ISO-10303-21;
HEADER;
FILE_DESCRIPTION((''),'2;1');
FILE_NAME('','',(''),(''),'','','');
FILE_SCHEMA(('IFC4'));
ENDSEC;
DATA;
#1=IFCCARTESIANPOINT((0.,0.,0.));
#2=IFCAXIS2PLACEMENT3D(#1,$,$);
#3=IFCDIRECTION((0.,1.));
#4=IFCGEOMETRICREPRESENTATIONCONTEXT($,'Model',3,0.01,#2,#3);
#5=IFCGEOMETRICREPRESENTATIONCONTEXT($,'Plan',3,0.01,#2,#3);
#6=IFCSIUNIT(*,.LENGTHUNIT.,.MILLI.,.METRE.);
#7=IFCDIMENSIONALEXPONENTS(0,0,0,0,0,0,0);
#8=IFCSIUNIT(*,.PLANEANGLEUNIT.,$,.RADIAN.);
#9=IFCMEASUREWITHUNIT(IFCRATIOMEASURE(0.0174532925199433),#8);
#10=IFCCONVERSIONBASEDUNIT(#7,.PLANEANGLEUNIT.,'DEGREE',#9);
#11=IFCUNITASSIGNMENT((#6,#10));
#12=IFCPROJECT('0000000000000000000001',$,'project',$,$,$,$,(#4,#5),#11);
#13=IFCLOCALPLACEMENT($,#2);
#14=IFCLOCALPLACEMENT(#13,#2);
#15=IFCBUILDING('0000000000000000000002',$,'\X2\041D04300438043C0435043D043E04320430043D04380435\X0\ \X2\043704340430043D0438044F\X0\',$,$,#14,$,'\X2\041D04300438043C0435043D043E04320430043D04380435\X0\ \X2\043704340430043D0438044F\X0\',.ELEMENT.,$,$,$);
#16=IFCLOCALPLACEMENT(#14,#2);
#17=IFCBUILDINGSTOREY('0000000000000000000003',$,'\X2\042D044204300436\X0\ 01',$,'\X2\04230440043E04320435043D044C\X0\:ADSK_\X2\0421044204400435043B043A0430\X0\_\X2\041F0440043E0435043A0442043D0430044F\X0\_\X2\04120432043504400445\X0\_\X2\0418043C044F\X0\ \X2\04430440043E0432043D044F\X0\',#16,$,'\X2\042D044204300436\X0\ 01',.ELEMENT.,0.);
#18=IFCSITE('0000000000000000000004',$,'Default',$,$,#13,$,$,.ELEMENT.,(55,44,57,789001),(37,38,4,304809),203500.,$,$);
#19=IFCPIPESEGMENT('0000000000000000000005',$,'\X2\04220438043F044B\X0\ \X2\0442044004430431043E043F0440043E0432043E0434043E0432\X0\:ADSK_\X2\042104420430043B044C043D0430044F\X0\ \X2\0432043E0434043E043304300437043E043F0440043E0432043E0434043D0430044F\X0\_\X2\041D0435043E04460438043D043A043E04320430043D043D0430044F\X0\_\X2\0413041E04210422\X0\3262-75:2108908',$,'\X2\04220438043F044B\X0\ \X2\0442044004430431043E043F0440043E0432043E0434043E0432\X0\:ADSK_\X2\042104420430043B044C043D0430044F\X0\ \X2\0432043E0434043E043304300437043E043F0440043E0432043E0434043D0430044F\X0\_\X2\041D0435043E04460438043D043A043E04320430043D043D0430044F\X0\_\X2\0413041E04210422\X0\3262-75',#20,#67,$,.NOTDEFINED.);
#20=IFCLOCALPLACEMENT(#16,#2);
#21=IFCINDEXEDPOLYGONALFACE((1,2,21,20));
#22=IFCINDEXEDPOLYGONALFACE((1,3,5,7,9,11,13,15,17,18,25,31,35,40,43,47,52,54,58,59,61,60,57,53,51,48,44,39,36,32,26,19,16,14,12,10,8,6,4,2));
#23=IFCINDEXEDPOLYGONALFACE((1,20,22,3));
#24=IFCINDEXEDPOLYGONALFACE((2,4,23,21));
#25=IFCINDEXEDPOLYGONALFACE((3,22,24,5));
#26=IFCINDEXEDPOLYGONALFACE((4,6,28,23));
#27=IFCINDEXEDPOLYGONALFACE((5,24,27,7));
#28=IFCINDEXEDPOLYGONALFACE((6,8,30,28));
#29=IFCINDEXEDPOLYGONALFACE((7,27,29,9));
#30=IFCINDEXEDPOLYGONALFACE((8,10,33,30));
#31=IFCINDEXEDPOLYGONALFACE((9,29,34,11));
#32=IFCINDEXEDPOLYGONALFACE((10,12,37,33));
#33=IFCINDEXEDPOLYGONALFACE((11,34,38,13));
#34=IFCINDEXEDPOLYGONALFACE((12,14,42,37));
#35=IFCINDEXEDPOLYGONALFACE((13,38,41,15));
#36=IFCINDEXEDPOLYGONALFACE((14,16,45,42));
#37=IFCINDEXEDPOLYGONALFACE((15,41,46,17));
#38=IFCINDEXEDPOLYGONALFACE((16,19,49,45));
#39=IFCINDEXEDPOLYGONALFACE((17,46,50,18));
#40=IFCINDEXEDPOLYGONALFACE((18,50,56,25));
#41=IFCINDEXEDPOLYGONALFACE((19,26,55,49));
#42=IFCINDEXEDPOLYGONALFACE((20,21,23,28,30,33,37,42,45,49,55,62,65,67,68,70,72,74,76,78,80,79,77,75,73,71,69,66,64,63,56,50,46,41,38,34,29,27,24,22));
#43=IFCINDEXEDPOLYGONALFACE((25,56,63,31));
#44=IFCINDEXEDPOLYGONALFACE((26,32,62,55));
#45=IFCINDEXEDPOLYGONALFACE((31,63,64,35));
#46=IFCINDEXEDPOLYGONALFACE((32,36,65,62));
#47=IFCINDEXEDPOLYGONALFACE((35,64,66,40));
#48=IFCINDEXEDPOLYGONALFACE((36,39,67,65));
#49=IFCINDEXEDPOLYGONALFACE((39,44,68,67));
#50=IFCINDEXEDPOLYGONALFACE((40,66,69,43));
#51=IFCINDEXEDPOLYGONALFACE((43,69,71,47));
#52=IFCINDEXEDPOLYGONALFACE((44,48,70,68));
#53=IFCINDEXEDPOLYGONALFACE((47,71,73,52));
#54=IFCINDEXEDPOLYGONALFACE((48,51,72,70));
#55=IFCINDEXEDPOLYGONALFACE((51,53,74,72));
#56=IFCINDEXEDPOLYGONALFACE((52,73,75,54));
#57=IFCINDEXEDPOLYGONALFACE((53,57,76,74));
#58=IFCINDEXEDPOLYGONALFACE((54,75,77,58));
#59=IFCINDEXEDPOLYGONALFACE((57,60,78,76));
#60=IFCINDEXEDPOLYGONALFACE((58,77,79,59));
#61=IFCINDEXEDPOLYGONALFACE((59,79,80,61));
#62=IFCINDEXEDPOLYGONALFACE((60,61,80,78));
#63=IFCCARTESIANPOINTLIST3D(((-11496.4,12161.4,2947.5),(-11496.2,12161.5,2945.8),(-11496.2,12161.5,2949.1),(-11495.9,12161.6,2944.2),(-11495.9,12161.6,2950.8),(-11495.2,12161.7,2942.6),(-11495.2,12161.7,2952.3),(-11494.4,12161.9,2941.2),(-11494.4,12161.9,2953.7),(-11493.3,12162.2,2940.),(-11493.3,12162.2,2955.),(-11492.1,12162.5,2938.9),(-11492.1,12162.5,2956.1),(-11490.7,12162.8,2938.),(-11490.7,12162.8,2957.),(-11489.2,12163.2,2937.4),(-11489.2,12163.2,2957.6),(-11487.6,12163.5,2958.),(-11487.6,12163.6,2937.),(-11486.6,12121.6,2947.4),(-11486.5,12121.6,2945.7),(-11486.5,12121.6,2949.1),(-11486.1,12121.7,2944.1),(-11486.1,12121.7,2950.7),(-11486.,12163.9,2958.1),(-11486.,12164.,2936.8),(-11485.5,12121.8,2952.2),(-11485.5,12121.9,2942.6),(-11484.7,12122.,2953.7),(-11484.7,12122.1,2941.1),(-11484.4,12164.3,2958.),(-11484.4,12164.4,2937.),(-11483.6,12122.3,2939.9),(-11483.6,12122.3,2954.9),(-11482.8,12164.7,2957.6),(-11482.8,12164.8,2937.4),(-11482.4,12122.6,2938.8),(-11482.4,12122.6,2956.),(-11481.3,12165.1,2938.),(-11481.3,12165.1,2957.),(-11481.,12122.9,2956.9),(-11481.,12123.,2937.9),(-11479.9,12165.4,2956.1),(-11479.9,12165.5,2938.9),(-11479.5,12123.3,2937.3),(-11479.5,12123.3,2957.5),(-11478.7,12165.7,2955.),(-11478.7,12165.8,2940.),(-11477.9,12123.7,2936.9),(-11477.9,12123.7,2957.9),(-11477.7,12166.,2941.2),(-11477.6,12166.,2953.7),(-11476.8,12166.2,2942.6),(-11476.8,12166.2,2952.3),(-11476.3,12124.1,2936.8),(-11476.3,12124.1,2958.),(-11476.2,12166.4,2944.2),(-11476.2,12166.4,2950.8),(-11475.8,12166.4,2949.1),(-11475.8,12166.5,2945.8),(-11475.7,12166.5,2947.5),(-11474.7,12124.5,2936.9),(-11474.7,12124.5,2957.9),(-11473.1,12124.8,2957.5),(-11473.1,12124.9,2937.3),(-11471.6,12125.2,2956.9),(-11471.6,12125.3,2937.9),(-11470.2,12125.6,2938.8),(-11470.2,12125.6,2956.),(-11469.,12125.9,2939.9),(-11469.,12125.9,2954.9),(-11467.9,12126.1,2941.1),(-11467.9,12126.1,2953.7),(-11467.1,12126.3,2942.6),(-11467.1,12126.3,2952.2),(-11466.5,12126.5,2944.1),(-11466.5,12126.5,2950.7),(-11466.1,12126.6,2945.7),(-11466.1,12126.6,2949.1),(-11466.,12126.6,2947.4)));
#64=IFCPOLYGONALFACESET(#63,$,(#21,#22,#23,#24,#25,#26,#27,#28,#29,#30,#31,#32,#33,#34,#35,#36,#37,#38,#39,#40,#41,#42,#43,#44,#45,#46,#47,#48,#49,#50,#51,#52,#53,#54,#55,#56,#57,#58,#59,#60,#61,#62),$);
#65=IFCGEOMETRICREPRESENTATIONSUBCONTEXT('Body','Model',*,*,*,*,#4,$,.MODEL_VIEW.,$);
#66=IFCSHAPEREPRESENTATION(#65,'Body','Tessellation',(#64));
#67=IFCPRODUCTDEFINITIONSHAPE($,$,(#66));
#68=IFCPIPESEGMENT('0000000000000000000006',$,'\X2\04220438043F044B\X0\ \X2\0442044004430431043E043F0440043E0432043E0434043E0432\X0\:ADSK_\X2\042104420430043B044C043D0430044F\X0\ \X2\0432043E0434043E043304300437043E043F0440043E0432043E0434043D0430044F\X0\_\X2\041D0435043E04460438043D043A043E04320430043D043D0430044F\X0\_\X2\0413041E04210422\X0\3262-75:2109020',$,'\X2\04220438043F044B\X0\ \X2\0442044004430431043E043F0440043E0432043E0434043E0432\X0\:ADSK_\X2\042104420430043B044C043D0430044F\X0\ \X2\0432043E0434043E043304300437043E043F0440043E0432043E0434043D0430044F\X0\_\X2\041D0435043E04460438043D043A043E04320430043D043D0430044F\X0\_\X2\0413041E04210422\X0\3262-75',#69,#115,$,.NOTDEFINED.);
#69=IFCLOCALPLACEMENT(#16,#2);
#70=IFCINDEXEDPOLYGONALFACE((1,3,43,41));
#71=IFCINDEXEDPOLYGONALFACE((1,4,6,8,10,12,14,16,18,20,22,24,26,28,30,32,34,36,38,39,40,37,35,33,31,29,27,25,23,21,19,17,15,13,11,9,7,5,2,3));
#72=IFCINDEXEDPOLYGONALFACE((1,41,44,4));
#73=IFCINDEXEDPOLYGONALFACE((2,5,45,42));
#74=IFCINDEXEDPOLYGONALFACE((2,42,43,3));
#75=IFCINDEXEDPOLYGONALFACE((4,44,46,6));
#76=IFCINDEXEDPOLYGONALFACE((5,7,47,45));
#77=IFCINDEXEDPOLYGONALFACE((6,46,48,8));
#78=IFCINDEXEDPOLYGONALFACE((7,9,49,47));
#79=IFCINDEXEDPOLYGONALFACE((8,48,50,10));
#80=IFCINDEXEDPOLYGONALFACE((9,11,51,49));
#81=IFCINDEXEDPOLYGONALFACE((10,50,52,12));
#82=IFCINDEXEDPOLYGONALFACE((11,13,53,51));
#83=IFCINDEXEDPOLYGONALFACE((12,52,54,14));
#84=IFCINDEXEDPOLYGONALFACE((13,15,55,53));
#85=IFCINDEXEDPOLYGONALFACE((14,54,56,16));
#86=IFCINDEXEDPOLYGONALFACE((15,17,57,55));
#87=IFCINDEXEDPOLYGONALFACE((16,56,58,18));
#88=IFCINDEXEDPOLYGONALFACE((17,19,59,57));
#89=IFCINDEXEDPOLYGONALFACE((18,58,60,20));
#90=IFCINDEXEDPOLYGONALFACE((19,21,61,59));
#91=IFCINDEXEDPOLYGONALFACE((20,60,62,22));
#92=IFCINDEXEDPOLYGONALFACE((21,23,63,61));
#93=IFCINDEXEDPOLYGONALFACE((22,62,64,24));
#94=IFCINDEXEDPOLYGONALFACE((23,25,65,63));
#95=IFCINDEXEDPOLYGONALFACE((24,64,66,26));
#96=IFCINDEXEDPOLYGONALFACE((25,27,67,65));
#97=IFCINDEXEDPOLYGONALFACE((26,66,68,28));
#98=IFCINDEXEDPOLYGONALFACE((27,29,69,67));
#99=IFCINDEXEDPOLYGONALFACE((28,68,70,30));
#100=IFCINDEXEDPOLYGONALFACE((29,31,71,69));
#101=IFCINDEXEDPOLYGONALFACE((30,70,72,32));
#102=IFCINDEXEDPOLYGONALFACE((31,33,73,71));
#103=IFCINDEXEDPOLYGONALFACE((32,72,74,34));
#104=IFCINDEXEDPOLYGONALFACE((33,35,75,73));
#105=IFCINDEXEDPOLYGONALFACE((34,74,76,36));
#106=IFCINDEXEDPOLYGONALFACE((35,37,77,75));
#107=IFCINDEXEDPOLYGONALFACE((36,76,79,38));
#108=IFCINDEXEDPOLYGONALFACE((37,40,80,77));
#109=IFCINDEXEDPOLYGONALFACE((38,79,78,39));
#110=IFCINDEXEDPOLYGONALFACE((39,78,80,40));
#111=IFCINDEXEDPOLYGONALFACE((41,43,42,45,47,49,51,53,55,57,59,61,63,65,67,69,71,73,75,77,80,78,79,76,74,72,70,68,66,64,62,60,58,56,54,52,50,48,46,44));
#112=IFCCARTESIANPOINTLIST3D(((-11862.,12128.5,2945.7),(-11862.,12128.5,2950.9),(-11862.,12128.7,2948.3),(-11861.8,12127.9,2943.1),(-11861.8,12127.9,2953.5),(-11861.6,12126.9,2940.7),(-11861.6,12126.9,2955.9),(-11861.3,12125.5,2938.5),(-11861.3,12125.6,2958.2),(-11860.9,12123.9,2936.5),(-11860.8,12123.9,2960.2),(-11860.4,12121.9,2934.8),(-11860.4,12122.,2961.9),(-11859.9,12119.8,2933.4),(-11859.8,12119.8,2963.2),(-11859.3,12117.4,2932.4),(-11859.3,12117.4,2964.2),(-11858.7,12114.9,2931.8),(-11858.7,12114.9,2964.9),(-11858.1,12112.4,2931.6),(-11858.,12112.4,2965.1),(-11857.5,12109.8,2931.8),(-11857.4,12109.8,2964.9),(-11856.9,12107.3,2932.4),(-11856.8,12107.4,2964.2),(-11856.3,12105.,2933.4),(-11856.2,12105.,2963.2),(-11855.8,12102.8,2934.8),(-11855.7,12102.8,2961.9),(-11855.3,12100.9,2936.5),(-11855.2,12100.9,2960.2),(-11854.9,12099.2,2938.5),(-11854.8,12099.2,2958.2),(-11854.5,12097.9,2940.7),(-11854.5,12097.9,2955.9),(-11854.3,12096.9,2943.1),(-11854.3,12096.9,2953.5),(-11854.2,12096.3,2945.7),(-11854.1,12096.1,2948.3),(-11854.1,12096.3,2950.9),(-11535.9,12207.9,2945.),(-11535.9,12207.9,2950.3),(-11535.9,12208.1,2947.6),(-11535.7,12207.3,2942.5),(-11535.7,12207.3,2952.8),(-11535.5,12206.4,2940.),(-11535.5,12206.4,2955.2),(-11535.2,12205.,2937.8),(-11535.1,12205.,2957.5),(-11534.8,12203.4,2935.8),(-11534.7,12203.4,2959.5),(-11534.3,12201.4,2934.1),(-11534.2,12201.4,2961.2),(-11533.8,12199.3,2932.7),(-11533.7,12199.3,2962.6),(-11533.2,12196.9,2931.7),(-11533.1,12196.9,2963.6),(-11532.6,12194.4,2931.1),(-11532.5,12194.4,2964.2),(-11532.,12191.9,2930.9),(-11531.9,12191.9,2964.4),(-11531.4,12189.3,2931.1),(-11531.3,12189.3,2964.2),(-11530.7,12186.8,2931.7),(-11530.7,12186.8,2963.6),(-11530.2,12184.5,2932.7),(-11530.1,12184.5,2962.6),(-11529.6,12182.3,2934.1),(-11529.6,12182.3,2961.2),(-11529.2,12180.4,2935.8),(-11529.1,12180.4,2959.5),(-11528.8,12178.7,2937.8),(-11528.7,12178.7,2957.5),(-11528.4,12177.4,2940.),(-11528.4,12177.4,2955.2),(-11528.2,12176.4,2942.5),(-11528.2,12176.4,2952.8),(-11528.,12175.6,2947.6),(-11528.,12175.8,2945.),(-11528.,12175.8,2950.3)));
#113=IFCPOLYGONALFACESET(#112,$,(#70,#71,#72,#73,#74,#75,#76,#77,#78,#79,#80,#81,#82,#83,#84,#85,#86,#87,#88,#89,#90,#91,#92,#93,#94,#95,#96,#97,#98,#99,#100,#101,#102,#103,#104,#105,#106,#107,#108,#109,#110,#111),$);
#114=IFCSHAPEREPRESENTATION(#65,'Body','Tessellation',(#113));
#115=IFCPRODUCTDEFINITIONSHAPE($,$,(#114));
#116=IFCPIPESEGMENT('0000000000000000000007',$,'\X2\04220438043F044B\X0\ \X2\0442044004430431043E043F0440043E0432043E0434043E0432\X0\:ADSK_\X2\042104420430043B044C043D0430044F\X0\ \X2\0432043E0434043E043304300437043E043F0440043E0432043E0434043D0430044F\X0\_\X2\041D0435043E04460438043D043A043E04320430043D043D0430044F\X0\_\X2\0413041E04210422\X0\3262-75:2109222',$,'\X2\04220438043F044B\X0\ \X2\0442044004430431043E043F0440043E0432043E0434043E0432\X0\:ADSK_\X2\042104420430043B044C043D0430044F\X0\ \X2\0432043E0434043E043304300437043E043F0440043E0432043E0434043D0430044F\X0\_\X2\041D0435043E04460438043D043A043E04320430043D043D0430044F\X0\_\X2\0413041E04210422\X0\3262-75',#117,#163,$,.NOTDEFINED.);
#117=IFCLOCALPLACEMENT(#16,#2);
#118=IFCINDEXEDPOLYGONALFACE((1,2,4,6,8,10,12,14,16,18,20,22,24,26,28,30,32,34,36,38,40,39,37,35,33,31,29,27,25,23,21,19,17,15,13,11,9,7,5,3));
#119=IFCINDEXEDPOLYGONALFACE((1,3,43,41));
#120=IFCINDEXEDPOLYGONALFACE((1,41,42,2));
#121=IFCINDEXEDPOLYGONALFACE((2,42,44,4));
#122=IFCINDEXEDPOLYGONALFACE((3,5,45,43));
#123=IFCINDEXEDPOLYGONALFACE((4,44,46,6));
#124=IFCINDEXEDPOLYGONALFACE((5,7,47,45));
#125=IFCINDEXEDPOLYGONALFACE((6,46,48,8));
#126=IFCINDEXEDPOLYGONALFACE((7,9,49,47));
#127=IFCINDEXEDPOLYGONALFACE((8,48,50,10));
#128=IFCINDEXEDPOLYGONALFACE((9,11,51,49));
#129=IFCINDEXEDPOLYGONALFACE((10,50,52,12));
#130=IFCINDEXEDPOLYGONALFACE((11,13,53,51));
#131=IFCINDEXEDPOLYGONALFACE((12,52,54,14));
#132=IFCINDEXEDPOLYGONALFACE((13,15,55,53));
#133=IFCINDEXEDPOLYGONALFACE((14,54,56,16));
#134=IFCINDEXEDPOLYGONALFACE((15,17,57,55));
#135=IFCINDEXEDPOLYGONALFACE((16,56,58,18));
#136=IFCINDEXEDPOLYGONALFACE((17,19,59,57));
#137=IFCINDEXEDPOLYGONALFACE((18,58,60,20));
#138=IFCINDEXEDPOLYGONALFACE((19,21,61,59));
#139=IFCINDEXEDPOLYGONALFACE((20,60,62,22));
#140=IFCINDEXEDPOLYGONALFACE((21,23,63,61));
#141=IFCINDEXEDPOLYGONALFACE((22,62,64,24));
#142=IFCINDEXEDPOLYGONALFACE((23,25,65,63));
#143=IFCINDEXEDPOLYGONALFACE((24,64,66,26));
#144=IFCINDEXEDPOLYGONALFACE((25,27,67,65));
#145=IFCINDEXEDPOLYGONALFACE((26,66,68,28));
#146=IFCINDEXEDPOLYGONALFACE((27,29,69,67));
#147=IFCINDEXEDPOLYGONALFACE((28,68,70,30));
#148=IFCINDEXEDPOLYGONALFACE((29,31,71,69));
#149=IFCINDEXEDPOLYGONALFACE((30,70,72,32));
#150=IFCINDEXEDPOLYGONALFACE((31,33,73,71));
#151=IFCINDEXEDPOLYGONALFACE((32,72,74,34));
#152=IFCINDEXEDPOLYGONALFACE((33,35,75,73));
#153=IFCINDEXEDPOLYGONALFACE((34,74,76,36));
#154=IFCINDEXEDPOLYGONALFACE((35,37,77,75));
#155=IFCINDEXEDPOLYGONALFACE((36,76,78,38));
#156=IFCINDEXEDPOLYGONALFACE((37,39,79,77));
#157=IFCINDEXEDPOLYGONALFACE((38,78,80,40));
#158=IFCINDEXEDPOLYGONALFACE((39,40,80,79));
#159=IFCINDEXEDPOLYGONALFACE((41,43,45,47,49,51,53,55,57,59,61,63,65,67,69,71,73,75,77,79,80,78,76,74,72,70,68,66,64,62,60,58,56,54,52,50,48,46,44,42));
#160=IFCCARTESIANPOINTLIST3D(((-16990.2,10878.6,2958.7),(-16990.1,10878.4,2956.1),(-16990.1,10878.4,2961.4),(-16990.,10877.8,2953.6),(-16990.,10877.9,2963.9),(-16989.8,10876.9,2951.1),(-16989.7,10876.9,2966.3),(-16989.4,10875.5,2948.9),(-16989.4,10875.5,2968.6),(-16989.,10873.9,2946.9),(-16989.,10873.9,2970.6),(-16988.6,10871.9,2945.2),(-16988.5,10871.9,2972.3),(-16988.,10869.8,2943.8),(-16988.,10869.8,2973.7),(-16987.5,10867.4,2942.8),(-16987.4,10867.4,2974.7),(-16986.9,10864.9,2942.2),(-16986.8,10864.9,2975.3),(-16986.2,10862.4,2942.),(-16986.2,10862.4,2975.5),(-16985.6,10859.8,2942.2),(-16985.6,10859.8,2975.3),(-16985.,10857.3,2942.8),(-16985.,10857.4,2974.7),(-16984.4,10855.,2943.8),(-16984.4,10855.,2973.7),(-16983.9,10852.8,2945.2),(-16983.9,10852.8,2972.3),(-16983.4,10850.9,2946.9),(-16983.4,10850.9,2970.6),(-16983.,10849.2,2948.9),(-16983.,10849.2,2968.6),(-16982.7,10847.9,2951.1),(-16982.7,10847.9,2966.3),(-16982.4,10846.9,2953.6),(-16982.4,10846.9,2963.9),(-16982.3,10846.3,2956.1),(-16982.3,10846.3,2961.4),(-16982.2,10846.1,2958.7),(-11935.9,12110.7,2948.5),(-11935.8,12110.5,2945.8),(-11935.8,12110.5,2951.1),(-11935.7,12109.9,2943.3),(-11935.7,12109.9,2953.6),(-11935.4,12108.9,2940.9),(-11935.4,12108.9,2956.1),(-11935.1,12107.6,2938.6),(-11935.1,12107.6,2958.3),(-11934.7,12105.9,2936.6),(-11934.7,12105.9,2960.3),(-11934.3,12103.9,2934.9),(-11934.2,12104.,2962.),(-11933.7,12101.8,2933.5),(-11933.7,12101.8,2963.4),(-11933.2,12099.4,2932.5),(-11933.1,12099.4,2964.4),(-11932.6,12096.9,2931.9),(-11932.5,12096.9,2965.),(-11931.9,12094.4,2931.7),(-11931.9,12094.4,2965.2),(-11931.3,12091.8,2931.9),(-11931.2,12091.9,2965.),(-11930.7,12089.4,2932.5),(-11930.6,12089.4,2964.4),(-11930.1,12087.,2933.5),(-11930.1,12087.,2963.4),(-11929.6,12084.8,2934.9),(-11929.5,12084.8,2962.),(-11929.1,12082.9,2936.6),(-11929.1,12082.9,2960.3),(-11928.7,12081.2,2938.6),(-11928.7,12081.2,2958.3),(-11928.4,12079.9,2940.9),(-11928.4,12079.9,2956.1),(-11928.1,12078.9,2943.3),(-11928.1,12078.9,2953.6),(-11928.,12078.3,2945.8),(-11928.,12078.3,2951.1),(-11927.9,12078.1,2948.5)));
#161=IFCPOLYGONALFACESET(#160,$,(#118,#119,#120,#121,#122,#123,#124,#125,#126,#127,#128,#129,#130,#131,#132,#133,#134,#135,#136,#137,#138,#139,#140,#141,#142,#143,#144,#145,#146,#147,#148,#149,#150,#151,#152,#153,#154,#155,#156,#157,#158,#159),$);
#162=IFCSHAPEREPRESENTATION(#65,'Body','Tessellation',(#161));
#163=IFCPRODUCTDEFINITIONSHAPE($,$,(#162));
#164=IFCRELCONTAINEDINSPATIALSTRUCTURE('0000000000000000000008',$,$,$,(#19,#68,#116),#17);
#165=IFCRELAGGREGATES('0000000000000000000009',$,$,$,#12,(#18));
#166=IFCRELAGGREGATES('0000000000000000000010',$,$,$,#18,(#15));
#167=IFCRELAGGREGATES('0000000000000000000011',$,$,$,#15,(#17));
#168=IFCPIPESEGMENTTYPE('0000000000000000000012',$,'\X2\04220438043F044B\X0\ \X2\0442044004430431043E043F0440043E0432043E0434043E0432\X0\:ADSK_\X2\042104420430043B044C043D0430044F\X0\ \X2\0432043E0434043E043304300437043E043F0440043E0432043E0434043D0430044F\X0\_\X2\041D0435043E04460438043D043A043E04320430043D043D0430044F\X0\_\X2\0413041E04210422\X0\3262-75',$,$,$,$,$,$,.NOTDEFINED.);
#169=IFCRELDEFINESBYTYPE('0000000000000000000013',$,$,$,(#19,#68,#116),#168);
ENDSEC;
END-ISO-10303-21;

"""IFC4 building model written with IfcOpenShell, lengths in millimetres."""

from ifc_helpers import new_model, entity, si_unit, converted_unit, direction, frame, origin, place, context, subcontext, project, spatial, indexed_curve, outline, extrude, type_object, element, save


model = new_model("IFC4")

# Units and contexts
model_context = context("Model", 3, precision=0.01, world=origin(), true_north=direction((0.0, 1.0)))
plan_context = context("Plan", 3, precision=0.01, world=origin(), true_north=direction((0.0, 1.0)))
body_context = subcontext(model_context, "Body", "Model", "MODEL_VIEW")
ifc_project = project(units=[si_unit("LENGTHUNIT", "METRE", prefix="MILLI"), converted_unit("PLANEANGLEUNIT", "DEGREE", entity("IfcRatioMeasure", 0.0174532925199433), si_unit("PLANEANGLEUNIT", "RADIAN"), dimensions=[0, 0, 0, 0, 0, 0, 0])], contexts=[model_context, plan_context])

# Site, building, storey
site_placement = place(None, origin())
site = spatial("IfcSite", under=ifc_project, at=site_placement, Name="Default", CompositionType="ELEMENT", RefLatitude=(55, 44, 57, 789001), RefLongitude=(37, 38, 4, 304809), RefElevation=203500.0)
building_placement = place(site_placement, origin())
building = spatial("IfcBuilding", under=site, at=building_placement, Name="Наименование здания", LongName="Наименование здания", CompositionType="ELEMENT")
storey_placement = place(building_placement, origin())
storey = spatial("IfcBuildingStorey", under=building, at=storey_placement, Name="Этаж 01", ObjectType="Уровень:ADSK_Стрелка_Проектная_Вверх_Имя уровня", LongName="Этаж 01", CompositionType="ELEMENT", Elevation=0.0)

# Pipe segments
pipe_segment_type = type_object("IfcPipeSegmentType", Name="Типы трубопроводов:ADSK_Стальная водогазопроводная_Неоцинкованная_ГОСТ3262-75", PredefinedType="NOTDEFINED")
placement = place(storey_placement, origin())
element("IfcPipeSegment", 1, at=placement, inside=storey, type_object=pipe_segment_type, Name="Типы трубопроводов:ADSK_Стальная водогазопроводная_Неоцинкованная_ГОСТ3262-75:2108908", ObjectType="Типы трубопроводов:ADSK_Стальная водогазопроводная_Неоцинкованная_ГОСТ3262-75", PredefinedType="NOTDEFINED", context=body_context, shape_type="SweptSolid", body=[
    extrude(outline(indexed_curve([(10.7, 0.0), (10.5, 1.7), (10.1, 3.3), (9.5, 4.8), (8.6, 6.3), (7.5, 7.5), (6.3, 8.6), (4.8, 9.5), (3.3, 10.1), (1.7, 10.5), (0.0, 10.7), (-1.7, 10.5), (-3.3, 10.1), (-4.8, 9.5), (-6.3, 8.6), (-7.5, 7.5), (-8.6, 6.3), (-9.5, 4.8), (-10.1, 3.3), (-10.5, 1.7), (-10.7, 0.0), (-10.5, -1.7), (-10.1, -3.3), (-9.5, -4.8), (-8.6, -6.3), (-7.5, -7.5), (-6.3, -8.6), (-4.8, -9.5), (-3.3, -10.1), (-1.7, -10.5), (0.0, -10.7), (1.7, -10.5), (3.3, -10.1), (4.8, -9.5), (6.3, -8.6), (7.5, -7.5), (8.6, -6.3), (9.5, -4.8), (10.1, -3.3), (10.5, -1.7), (10.7, 0.0)], self_intersect=False)), frame((-11476.3, 12124.1, 2947.4), z_axis=(-0.236826, 0.97155, 0.002), x_axis=(0.971552, 0.236826, 0.0)), (0.0, 0.0, 1.0), 41.0),
])
element("IfcPipeSegment", 2, at=placement, inside=storey, type_object=pipe_segment_type, Name="Типы трубопроводов:ADSK_Стальная водогазопроводная_Неоцинкованная_ГОСТ3262-75:2109020", ObjectType="Типы трубопроводов:ADSK_Стальная водогазопроводная_Неоцинкованная_ГОСТ3262-75", PredefinedType="NOTDEFINED", context=body_context, shape_type="SweptSolid", body=[
    extrude(outline(indexed_curve([(16.8, 0.0), (16.5, 2.6), (15.9, 5.2), (14.9, 7.6), (13.6, 9.8), (11.8, 11.8), (9.8, 13.6), (7.6, 14.9), (5.2, 15.9), (2.6, 16.5), (0.0, 16.7), (-2.6, 16.5), (-5.2, 15.9), (-7.6, 14.9), (-9.8, 13.6), (-11.8, 11.8), (-13.6, 9.8), (-14.9, 7.6), (-15.9, 5.2), (-16.5, 2.6), (-16.8, 0.0), (-16.5, -2.6), (-15.9, -5.2), (-14.9, -7.6), (-13.6, -9.8), (-11.8, -11.8), (-9.8, -13.6), (-7.6, -14.9), (-5.2, -15.9), (-2.6, -16.5), (0.0, -16.7), (2.6, -16.5), (5.2, -15.9), (7.6, -14.9), (9.8, -13.6), (11.8, -11.8), (13.6, -9.8), (14.9, -7.6), (15.9, -5.2), (16.5, -2.6), (16.8, 0.0)], self_intersect=False)), frame((-11531.9, 12191.9, 2947.6), z_axis=(-0.971557, -0.236796, 0.002), x_axis=(0.236796, -0.971559, 0.0)), (0.0, 0.0, 1.0), 335.7),
])
element("IfcPipeSegment", 3, at=placement, inside=storey, type_object=pipe_segment_type, Name="Типы трубопроводов:ADSK_Стальная водогазопроводная_Неоцинкованная_ГОСТ3262-75:2109222", ObjectType="Типы трубопроводов:ADSK_Стальная водогазопроводная_Неоцинкованная_ГОСТ3262-75", PredefinedType="NOTDEFINED", context=body_context, shape_type="SweptSolid", body=[
    extrude(outline(indexed_curve([(16.8, 0.0), (16.5, 2.6), (15.9, 5.2), (14.9, 7.6), (13.6, 9.8), (11.8, 11.8), (9.8, 13.6), (7.6, 14.9), (5.2, 15.9), (2.6, 16.5), (0.0, 16.8), (-2.6, 16.5), (-5.2, 15.9), (-7.6, 14.9), (-9.8, 13.6), (-11.8, 11.8), (-13.6, 9.8), (-14.9, 7.6), (-15.9, 5.2), (-16.5, 2.6), (-16.8, 0.0), (-16.5, -2.6), (-15.9, -5.2), (-14.9, -7.6), (-13.6, -9.8), (-11.8, -11.8), (-9.8, -13.6), (-7.6, -14.9), (-5.2, -15.9), (-2.6, -16.5), (0.0, -16.7), (2.6, -16.5), (5.2, -15.9), (7.6, -14.9), (9.8, -13.6), (11.8, -11.8), (13.6, -9.8), (14.9, -7.6), (15.9, -5.2), (16.5, -2.6), (16.8, 0.0)], self_intersect=False)), frame((-11931.9, 12094.4, 2948.5), z_axis=(-0.971551, -0.236821, 0.001977), x_axis=(0.236822, -0.971553, 0.0)), (0.0, 0.0, 1.0), 5202.3),
])

save(model, "model.ifc")
